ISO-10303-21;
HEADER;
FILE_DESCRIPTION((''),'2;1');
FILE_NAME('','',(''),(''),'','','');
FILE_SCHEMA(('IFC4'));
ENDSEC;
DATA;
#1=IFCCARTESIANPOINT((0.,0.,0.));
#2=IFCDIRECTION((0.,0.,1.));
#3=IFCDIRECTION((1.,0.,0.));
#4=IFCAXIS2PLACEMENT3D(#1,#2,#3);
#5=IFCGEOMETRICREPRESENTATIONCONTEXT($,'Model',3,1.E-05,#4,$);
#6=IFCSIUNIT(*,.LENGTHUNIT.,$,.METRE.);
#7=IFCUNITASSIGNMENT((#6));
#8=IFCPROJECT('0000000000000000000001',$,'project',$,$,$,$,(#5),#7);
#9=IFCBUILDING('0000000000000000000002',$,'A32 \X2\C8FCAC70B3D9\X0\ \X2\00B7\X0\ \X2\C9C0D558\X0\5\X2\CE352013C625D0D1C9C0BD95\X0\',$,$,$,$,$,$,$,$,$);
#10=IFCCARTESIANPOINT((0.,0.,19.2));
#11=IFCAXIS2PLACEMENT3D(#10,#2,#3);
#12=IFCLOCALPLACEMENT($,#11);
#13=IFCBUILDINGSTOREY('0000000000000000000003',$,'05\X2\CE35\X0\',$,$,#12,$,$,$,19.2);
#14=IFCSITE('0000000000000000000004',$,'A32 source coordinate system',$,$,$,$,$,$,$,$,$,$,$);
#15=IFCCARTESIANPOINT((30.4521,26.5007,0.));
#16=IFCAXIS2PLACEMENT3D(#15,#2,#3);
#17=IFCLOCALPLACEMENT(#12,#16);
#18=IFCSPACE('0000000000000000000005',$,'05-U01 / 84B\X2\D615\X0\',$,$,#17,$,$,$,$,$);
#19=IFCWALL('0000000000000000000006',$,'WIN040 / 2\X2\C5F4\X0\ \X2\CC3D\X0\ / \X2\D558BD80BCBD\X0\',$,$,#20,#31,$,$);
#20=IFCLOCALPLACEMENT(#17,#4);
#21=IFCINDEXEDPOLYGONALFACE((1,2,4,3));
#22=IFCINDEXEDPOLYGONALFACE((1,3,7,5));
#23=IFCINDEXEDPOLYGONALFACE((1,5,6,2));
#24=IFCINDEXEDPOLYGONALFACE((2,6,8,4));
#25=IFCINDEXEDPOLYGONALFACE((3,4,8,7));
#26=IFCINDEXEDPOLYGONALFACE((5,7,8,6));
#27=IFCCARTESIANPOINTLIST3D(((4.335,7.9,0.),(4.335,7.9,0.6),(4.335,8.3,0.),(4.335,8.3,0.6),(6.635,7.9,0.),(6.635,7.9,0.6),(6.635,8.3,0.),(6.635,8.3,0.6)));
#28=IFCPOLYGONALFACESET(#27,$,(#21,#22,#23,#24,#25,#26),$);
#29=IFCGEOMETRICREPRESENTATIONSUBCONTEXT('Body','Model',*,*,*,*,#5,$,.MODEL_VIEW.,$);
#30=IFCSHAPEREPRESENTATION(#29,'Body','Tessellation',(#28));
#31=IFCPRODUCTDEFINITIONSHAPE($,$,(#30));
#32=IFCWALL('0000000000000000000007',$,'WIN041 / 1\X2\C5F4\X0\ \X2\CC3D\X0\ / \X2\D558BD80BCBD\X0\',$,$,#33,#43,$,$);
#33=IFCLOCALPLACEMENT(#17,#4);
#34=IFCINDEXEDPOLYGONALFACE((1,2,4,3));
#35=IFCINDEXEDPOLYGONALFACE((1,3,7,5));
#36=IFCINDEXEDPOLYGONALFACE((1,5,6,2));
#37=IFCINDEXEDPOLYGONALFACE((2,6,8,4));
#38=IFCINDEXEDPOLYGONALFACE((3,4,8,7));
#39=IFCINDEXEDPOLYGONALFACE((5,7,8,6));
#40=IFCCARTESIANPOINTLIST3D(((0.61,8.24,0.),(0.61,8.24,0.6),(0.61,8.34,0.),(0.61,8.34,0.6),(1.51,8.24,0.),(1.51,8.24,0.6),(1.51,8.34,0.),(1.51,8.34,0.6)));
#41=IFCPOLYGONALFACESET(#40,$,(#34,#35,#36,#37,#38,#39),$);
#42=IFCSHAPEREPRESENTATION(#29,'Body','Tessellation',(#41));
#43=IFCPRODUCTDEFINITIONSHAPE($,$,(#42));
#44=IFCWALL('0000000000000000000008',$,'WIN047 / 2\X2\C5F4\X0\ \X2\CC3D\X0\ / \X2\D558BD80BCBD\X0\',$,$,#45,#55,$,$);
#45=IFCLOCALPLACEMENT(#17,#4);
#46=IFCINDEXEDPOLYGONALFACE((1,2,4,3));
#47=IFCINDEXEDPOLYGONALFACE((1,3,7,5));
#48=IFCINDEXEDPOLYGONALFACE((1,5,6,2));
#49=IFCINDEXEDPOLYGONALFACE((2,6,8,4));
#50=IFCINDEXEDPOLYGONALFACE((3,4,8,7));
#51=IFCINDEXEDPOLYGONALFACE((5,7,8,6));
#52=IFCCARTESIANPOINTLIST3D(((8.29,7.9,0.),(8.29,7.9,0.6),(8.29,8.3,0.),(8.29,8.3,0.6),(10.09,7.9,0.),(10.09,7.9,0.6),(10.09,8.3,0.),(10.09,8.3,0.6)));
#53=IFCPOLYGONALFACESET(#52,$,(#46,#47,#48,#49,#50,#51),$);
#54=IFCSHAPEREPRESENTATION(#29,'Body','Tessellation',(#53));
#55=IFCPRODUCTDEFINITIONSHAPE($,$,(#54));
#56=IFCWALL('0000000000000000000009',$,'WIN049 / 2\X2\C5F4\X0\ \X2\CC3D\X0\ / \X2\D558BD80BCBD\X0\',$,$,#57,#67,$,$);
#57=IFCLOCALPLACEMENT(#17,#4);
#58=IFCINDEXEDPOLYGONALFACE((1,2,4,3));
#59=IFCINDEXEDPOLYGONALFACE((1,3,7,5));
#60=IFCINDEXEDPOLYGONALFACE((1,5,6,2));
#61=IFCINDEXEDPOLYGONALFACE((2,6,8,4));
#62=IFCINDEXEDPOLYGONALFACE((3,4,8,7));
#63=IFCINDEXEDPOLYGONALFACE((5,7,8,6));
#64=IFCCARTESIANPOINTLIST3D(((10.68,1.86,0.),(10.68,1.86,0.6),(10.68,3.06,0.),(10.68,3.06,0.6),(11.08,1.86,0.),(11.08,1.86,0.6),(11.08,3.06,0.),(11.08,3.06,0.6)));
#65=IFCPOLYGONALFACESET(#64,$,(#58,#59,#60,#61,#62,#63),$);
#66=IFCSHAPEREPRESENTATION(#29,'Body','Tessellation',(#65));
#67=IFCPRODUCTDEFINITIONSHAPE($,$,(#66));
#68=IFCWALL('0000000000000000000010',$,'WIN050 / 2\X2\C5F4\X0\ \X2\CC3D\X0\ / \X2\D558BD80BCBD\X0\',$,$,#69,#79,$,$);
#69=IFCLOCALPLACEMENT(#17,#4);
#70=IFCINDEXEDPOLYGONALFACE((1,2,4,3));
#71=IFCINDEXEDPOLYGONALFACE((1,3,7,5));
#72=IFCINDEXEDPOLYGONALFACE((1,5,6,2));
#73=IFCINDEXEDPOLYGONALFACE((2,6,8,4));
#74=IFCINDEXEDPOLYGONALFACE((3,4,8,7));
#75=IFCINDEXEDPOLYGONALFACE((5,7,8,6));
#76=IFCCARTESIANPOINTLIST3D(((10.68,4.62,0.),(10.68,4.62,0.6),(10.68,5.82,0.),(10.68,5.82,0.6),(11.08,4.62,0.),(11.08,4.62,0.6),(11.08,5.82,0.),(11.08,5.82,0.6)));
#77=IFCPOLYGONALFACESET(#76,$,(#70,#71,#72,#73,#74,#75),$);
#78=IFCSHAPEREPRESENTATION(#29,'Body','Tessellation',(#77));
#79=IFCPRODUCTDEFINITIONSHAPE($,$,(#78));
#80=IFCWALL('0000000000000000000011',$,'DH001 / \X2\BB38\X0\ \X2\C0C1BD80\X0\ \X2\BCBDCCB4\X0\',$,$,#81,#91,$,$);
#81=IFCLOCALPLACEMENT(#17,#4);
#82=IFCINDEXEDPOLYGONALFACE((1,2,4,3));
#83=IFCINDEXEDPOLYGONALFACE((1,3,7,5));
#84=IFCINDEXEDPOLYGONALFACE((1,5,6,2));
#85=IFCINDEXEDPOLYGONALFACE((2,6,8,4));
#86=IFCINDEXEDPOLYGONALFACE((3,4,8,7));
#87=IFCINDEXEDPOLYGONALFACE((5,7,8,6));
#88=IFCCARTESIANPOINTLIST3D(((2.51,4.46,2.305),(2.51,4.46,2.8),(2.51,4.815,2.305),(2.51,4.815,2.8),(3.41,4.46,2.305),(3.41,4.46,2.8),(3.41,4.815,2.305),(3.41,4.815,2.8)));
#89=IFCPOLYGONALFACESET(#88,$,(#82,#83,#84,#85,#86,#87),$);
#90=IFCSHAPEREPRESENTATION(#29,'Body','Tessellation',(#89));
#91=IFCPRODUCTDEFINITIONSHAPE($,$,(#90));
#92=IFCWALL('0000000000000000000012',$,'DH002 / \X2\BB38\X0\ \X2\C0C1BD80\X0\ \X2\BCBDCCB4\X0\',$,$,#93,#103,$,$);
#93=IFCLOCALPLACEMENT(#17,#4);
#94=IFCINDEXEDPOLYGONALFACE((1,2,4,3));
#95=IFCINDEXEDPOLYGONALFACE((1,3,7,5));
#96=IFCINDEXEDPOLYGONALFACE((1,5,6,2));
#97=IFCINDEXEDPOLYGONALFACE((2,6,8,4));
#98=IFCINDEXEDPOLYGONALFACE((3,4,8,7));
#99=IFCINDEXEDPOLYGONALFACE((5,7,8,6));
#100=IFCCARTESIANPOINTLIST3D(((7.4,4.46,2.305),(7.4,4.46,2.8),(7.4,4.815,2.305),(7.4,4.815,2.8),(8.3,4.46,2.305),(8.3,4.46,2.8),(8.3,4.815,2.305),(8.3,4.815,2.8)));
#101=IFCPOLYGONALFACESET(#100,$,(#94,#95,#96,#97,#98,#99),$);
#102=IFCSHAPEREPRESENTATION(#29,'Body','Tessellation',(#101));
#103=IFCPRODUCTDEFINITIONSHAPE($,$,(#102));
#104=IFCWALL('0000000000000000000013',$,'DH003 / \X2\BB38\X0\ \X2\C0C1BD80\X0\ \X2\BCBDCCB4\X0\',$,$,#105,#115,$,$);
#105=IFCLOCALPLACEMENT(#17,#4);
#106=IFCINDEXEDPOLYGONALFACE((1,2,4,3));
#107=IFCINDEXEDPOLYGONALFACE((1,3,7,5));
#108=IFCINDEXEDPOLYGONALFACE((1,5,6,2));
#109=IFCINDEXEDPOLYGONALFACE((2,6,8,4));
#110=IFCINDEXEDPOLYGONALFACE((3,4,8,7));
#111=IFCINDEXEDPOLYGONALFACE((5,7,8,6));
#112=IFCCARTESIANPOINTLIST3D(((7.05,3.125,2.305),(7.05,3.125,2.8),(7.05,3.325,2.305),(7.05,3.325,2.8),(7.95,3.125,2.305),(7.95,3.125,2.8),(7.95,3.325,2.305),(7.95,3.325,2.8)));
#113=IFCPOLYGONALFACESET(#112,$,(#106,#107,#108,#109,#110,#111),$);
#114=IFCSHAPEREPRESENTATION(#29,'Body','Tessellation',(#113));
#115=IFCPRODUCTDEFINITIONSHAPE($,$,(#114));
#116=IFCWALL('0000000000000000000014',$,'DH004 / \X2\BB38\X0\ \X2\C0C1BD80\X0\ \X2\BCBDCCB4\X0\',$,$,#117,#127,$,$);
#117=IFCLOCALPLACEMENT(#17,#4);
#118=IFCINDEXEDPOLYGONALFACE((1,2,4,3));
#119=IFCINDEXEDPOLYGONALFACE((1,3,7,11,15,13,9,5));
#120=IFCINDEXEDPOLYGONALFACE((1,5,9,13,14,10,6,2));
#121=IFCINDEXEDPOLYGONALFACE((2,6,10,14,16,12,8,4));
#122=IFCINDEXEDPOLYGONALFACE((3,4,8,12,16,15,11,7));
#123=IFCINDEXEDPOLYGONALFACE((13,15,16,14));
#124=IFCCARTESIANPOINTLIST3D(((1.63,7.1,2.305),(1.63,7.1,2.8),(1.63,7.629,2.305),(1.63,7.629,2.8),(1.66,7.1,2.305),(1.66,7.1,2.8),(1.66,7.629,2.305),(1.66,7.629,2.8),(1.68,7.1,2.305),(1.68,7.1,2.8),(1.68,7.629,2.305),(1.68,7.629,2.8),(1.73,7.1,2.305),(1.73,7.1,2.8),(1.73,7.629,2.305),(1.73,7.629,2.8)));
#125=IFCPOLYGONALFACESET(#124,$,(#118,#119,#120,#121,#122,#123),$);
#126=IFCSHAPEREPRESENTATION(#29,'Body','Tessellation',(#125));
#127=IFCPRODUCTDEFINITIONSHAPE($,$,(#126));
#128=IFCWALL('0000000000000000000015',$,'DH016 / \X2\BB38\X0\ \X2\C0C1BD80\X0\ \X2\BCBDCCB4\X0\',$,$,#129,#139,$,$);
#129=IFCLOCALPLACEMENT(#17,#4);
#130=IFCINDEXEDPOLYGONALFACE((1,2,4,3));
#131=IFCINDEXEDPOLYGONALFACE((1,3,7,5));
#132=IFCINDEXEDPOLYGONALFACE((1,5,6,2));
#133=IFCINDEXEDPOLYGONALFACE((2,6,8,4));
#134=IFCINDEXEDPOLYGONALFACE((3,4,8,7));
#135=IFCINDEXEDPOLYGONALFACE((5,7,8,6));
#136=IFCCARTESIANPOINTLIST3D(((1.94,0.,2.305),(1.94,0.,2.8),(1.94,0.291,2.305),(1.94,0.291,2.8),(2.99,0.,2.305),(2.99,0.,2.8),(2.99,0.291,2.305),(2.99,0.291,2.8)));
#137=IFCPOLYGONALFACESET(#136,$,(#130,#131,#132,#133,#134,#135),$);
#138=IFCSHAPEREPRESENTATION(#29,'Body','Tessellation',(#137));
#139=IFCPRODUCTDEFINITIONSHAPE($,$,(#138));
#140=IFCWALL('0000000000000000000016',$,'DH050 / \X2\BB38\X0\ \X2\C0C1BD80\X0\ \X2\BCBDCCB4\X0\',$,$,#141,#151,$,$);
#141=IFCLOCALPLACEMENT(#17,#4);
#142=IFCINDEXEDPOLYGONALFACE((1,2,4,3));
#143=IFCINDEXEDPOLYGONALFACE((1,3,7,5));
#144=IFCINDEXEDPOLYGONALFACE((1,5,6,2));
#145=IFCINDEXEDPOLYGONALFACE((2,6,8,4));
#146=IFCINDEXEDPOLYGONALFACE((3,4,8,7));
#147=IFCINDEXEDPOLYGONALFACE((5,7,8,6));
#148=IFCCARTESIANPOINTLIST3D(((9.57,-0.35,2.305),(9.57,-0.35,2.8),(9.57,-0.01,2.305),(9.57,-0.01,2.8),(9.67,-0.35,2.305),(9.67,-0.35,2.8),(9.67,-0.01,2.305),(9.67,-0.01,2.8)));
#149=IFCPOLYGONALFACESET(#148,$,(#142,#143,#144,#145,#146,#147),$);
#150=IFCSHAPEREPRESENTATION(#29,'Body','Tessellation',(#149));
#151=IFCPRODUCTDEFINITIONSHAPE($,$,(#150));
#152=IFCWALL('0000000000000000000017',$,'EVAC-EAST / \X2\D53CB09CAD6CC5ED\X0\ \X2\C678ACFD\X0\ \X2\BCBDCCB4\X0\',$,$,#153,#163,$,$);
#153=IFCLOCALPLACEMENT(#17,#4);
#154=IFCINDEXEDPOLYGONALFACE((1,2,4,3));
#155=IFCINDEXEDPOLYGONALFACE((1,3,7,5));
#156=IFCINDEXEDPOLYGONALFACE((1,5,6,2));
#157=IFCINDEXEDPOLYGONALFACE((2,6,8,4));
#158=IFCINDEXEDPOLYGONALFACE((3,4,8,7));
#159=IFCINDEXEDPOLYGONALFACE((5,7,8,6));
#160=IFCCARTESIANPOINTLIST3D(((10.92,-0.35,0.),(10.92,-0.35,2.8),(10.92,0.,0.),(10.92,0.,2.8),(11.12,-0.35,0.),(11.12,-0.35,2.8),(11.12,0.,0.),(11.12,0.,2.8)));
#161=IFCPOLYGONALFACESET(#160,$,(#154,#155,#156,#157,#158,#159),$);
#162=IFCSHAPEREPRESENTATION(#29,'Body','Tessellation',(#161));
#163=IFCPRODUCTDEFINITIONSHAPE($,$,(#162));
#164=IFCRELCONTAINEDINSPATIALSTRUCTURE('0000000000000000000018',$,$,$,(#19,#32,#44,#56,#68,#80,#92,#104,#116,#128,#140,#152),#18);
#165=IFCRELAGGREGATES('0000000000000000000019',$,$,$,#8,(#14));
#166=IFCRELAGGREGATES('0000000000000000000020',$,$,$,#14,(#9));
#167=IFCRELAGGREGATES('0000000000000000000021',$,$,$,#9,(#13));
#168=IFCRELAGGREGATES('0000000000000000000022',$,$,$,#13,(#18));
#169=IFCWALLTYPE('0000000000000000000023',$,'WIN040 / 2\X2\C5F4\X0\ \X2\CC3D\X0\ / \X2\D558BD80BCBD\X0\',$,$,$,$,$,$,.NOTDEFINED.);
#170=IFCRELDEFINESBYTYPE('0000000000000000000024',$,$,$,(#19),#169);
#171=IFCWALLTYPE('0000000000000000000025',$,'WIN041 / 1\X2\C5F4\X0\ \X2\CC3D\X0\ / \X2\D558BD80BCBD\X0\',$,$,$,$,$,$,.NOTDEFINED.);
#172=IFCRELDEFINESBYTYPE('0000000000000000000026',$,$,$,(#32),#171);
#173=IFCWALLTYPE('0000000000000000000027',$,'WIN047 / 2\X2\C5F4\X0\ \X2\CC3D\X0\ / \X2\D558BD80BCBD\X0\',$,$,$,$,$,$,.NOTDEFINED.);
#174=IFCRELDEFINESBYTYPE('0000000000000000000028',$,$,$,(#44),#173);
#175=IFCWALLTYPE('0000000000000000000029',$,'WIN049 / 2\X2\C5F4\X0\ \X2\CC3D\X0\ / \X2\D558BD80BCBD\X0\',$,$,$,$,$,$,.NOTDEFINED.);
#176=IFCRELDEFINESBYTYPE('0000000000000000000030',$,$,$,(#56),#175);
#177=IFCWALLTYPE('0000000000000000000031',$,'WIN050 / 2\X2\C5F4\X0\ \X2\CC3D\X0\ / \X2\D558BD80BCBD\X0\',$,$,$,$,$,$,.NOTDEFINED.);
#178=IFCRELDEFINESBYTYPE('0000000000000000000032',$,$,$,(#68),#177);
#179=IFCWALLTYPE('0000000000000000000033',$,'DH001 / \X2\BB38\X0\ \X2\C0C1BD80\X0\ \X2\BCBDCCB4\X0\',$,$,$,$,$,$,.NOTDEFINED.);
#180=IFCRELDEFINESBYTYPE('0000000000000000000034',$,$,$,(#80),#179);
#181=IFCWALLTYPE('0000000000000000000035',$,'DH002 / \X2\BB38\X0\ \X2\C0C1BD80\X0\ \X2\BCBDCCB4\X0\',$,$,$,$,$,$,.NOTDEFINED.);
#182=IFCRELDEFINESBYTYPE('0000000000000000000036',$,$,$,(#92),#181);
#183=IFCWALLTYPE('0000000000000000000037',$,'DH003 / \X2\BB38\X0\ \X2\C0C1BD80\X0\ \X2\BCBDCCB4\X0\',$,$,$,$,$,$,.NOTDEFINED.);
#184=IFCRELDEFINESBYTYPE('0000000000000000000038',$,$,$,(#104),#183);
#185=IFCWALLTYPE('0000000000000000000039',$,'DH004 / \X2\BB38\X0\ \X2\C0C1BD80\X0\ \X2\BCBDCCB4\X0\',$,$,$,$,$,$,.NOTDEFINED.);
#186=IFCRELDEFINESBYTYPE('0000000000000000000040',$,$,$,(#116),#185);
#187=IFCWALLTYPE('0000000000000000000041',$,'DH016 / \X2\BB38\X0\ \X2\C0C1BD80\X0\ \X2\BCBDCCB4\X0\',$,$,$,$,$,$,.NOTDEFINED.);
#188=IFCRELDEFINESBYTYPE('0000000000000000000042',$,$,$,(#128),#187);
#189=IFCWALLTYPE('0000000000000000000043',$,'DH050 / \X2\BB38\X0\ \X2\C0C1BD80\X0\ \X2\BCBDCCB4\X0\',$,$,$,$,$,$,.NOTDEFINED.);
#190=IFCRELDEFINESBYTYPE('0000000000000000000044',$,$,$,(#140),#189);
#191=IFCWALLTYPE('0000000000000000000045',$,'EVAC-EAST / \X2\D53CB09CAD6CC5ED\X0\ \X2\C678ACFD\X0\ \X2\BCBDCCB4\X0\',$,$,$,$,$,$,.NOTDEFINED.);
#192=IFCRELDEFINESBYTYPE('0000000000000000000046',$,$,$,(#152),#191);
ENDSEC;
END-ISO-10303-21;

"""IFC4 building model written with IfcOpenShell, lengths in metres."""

from ifc_helpers import new_model, si_unit, frame, origin, origin_with_axes, place, context, subcontext, project, spatial, polyline, outline, extrude, source, transform, mapped, type_object, type_shapes, element, save


model = new_model("IFC4")

# Units and contexts
model_context = context("Model", 3, precision=1e-05, world=origin_with_axes())
body_context = subcontext(model_context, "Body", "Model", "MODEL_VIEW")
ifc_project = project(units=[si_unit("LENGTHUNIT", "METRE")], contexts=[model_context])

# Site, building, storey, space
site = spatial("IfcSite", under=ifc_project, Name="A32 source coordinate system")
building = spatial("IfcBuilding", under=site, Name="A32 주거동 · 지하5층–옥탑지붕")
storey_placement = place(None, frame((0.0, 0.0, 19.2), z_axis=(0.0, 0.0, 1.0), x_axis=(1.0, 0.0, 0.0)))
storey = spatial("IfcBuildingStorey", under=building, at=storey_placement, Name="05층", Elevation=19.2)
space_placement = place(storey_placement, frame((30.4521, 26.5007, 0.0), z_axis=(0.0, 0.0, 1.0), x_axis=(1.0, 0.0, 0.0)))
space = spatial("IfcSpace", under=storey, at=space_placement, Name="05-U01 / 84B형")

# Walls
wall_type_1 = type_object("IfcWallType", Name="WIN040 / 2열 창 / 하부벽", PredefinedType="NOTDEFINED")
shared_shape_1 = source(origin(), body_context, "Body", "SweptSolid", [
    extrude(outline(polyline([(4.335, 8.3), (6.635, 8.3), (6.635, 7.9), (4.335, 7.9), (4.335, 8.3)])), origin(), (0.0, 0.0, 1.0), 0.6),
])
type_shapes(wall_type_1, [shared_shape_1])
wall_1_placement = place(space_placement, origin_with_axes())
element("IfcWall", 1, at=wall_1_placement, inside=space, type_object=wall_type_1, Name="WIN040 / 2열 창 / 하부벽", context=body_context, shape_type="MappedRepresentation", body=[
    mapped(shared_shape_1, transform((0.0, 0.0, 0.0), scale=1.0)),
])
wall_type_2 = type_object("IfcWallType", Name="WIN041 / 1열 창 / 하부벽", PredefinedType="NOTDEFINED")
shared_shape_2 = source(origin(), body_context, "Body", "SweptSolid", [
    extrude(outline(polyline([(0.61, 8.34), (1.51, 8.34), (1.51, 8.24), (0.61, 8.24), (0.61, 8.34)])), origin(), (0.0, 0.0, 1.0), 0.6),
])
type_shapes(wall_type_2, [shared_shape_2])
wall_2_placement = place(space_placement, origin_with_axes())
element("IfcWall", 2, at=wall_2_placement, inside=space, type_object=wall_type_2, Name="WIN041 / 1열 창 / 하부벽", context=body_context, shape_type="MappedRepresentation", body=[
    mapped(shared_shape_2, transform((0.0, 0.0, 0.0), scale=1.0)),
])
wall_type_3 = type_object("IfcWallType", Name="WIN047 / 2열 창 / 하부벽", PredefinedType="NOTDEFINED")
shared_shape_3 = source(origin(), body_context, "Body", "SweptSolid", [
    extrude(outline(polyline([(8.29, 8.3), (10.09, 8.3), (10.09, 7.9), (8.29, 7.9), (8.29, 8.3)])), origin(), (0.0, 0.0, 1.0), 0.6),
])
type_shapes(wall_type_3, [shared_shape_3])
wall_3_placement = place(space_placement, origin_with_axes())
element("IfcWall", 3, at=wall_3_placement, inside=space, type_object=wall_type_3, Name="WIN047 / 2열 창 / 하부벽", context=body_context, shape_type="MappedRepresentation", body=[
    mapped(shared_shape_3, transform((0.0, 0.0, 0.0), scale=1.0)),
])
wall_type_4 = type_object("IfcWallType", Name="WIN049 / 2열 창 / 하부벽", PredefinedType="NOTDEFINED")
shared_shape_4 = source(origin(), body_context, "Body", "SweptSolid", [
    extrude(outline(polyline([(10.68, 3.06), (11.08, 3.06), (11.08, 1.86), (10.68, 1.86), (10.68, 3.06)])), origin(), (0.0, 0.0, 1.0), 0.6),
])
type_shapes(wall_type_4, [shared_shape_4])
wall_4_placement = place(space_placement, origin_with_axes())
element("IfcWall", 4, at=wall_4_placement, inside=space, type_object=wall_type_4, Name="WIN049 / 2열 창 / 하부벽", context=body_context, shape_type="MappedRepresentation", body=[
    mapped(shared_shape_4, transform((0.0, 0.0, 0.0), scale=1.0)),
])
wall_type_5 = type_object("IfcWallType", Name="WIN050 / 2열 창 / 하부벽", PredefinedType="NOTDEFINED")
shared_shape_5 = source(origin(), body_context, "Body", "SweptSolid", [
    extrude(outline(polyline([(10.68, 5.82), (11.08, 5.82), (11.08, 4.62), (10.68, 4.62), (10.68, 5.82)])), origin(), (0.0, 0.0, 1.0), 0.6),
])
type_shapes(wall_type_5, [shared_shape_5])
wall_5_placement = place(space_placement, origin_with_axes())
element("IfcWall", 5, at=wall_5_placement, inside=space, type_object=wall_type_5, Name="WIN050 / 2열 창 / 하부벽", context=body_context, shape_type="MappedRepresentation", body=[
    mapped(shared_shape_5, transform((0.0, 0.0, 0.0), scale=1.0)),
])
wall_type_6 = type_object("IfcWallType", Name="DH001 / 문 상부 벽체", PredefinedType="NOTDEFINED")
shared_shape_6 = source(origin(), body_context, "Body", "SweptSolid", [
    extrude(outline(polyline([(3.41, 4.815), (3.41, 4.46), (2.51, 4.46), (2.51, 4.815), (3.41, 4.815)])), frame((0.0, 0.0, 2.305)), (0.0, 0.0, 1.0), 0.495),
])
type_shapes(wall_type_6, [shared_shape_6])
wall_6_placement = place(space_placement, origin_with_axes())
element("IfcWall", 6, at=wall_6_placement, inside=space, type_object=wall_type_6, Name="DH001 / 문 상부 벽체", context=body_context, shape_type="MappedRepresentation", body=[
    mapped(shared_shape_6, transform((0.0, 0.0, 0.0), scale=1.0)),
])
wall_type_7 = type_object("IfcWallType", Name="DH002 / 문 상부 벽체", PredefinedType="NOTDEFINED")
shared_shape_7 = source(origin(), body_context, "Body", "SweptSolid", [
    extrude(outline(polyline([(8.3, 4.815), (8.3, 4.46), (7.4, 4.46), (7.4, 4.815), (8.3, 4.815)])), frame((0.0, 0.0, 2.305)), (0.0, 0.0, 1.0), 0.495),
])
type_shapes(wall_type_7, [shared_shape_7])
wall_7_placement = place(space_placement, origin_with_axes())
element("IfcWall", 7, at=wall_7_placement, inside=space, type_object=wall_type_7, Name="DH002 / 문 상부 벽체", context=body_context, shape_type="MappedRepresentation", body=[
    mapped(shared_shape_7, transform((0.0, 0.0, 0.0), scale=1.0)),
])
wall_type_8 = type_object("IfcWallType", Name="DH003 / 문 상부 벽체", PredefinedType="NOTDEFINED")
shared_shape_8 = source(origin(), body_context, "Body", "SweptSolid", [
    extrude(outline(polyline([(7.95, 3.325), (7.95, 3.125), (7.05, 3.125), (7.05, 3.325), (7.95, 3.325)])), frame((0.0, 0.0, 2.305)), (0.0, 0.0, 1.0), 0.495),
])
type_shapes(wall_type_8, [shared_shape_8])
wall_8_placement = place(space_placement, origin_with_axes())
element("IfcWall", 8, at=wall_8_placement, inside=space, type_object=wall_type_8, Name="DH003 / 문 상부 벽체", context=body_context, shape_type="MappedRepresentation", body=[
    mapped(shared_shape_8, transform((0.0, 0.0, 0.0), scale=1.0)),
])
wall_type_9 = type_object("IfcWallType", Name="DH004 / 문 상부 벽체", PredefinedType="NOTDEFINED")
shared_shape_9 = source(origin(), body_context, "Body", "SweptSolid", [
    extrude(outline(polyline([(1.66, 7.1), (1.63, 7.1), (1.63, 7.629), (1.66, 7.629), (1.68, 7.629), (1.73, 7.629), (1.73, 7.1), (1.68, 7.1), (1.66, 7.1)])), frame((0.0, 0.0, 2.305)), (0.0, 0.0, 1.0), 0.495),
])
type_shapes(wall_type_9, [shared_shape_9])
wall_9_placement = place(space_placement, origin_with_axes())
element("IfcWall", 9, at=wall_9_placement, inside=space, type_object=wall_type_9, Name="DH004 / 문 상부 벽체", context=body_context, shape_type="MappedRepresentation", body=[
    mapped(shared_shape_9, transform((0.0, 0.0, 0.0), scale=1.0)),
])
wall_type_10 = type_object("IfcWallType", Name="DH016 / 문 상부 벽체", PredefinedType="NOTDEFINED")
shared_shape_10 = source(origin(), body_context, "Body", "SweptSolid", [
    extrude(outline(polyline([(2.99, 0.291), (2.99, 0.0), (1.94, 0.0), (1.94, 0.291), (2.99, 0.291)])), frame((0.0, 0.0, 2.305)), (0.0, 0.0, 1.0), 0.495),
])
type_shapes(wall_type_10, [shared_shape_10])
wall_10_placement = place(space_placement, origin_with_axes())
element("IfcWall", 10, at=wall_10_placement, inside=space, type_object=wall_type_10, Name="DH016 / 문 상부 벽체", context=body_context, shape_type="MappedRepresentation", body=[
    mapped(shared_shape_10, transform((0.0, 0.0, 0.0), scale=1.0)),
])
wall_type_11 = type_object("IfcWallType", Name="DH050 / 문 상부 벽체", PredefinedType="NOTDEFINED")
shared_shape_11 = source(origin(), body_context, "Body", "SweptSolid", [
    extrude(outline(polyline([(9.67, -0.01), (9.67, -0.35), (9.57, -0.35), (9.57, -0.01), (9.67, -0.01)])), frame((0.0, 0.0, 2.305)), (0.0, 0.0, 1.0), 0.495),
])
type_shapes(wall_type_11, [shared_shape_11])
wall_11_placement = place(space_placement, origin_with_axes())
element("IfcWall", 11, at=wall_11_placement, inside=space, type_object=wall_type_11, Name="DH050 / 문 상부 벽체", context=body_context, shape_type="MappedRepresentation", body=[
    mapped(shared_shape_11, transform((0.0, 0.0, 0.0), scale=1.0)),
])
wall_type_12 = type_object("IfcWallType", Name="EVAC-EAST / 피난구역 외곽 벽체", PredefinedType="NOTDEFINED")
shared_shape_12 = source(origin(), body_context, "Body", "SweptSolid", [
    extrude(outline(polyline([(10.92, 0.0), (11.12, 0.0), (11.12, -0.35), (10.92, -0.35), (10.92, 0.0)])), origin(), (0.0, 0.0, 1.0), 2.8),
])
type_shapes(wall_type_12, [shared_shape_12])
wall_12_placement = place(space_placement, origin_with_axes())
element("IfcWall", 12, at=wall_12_placement, inside=space, type_object=wall_type_12, Name="EVAC-EAST / 피난구역 외곽 벽체", context=body_context, shape_type="MappedRepresentation", body=[
    mapped(shared_shape_12, transform((0.0, 0.0, 0.0), scale=1.0)),
])

save(model, "model.ifc")
